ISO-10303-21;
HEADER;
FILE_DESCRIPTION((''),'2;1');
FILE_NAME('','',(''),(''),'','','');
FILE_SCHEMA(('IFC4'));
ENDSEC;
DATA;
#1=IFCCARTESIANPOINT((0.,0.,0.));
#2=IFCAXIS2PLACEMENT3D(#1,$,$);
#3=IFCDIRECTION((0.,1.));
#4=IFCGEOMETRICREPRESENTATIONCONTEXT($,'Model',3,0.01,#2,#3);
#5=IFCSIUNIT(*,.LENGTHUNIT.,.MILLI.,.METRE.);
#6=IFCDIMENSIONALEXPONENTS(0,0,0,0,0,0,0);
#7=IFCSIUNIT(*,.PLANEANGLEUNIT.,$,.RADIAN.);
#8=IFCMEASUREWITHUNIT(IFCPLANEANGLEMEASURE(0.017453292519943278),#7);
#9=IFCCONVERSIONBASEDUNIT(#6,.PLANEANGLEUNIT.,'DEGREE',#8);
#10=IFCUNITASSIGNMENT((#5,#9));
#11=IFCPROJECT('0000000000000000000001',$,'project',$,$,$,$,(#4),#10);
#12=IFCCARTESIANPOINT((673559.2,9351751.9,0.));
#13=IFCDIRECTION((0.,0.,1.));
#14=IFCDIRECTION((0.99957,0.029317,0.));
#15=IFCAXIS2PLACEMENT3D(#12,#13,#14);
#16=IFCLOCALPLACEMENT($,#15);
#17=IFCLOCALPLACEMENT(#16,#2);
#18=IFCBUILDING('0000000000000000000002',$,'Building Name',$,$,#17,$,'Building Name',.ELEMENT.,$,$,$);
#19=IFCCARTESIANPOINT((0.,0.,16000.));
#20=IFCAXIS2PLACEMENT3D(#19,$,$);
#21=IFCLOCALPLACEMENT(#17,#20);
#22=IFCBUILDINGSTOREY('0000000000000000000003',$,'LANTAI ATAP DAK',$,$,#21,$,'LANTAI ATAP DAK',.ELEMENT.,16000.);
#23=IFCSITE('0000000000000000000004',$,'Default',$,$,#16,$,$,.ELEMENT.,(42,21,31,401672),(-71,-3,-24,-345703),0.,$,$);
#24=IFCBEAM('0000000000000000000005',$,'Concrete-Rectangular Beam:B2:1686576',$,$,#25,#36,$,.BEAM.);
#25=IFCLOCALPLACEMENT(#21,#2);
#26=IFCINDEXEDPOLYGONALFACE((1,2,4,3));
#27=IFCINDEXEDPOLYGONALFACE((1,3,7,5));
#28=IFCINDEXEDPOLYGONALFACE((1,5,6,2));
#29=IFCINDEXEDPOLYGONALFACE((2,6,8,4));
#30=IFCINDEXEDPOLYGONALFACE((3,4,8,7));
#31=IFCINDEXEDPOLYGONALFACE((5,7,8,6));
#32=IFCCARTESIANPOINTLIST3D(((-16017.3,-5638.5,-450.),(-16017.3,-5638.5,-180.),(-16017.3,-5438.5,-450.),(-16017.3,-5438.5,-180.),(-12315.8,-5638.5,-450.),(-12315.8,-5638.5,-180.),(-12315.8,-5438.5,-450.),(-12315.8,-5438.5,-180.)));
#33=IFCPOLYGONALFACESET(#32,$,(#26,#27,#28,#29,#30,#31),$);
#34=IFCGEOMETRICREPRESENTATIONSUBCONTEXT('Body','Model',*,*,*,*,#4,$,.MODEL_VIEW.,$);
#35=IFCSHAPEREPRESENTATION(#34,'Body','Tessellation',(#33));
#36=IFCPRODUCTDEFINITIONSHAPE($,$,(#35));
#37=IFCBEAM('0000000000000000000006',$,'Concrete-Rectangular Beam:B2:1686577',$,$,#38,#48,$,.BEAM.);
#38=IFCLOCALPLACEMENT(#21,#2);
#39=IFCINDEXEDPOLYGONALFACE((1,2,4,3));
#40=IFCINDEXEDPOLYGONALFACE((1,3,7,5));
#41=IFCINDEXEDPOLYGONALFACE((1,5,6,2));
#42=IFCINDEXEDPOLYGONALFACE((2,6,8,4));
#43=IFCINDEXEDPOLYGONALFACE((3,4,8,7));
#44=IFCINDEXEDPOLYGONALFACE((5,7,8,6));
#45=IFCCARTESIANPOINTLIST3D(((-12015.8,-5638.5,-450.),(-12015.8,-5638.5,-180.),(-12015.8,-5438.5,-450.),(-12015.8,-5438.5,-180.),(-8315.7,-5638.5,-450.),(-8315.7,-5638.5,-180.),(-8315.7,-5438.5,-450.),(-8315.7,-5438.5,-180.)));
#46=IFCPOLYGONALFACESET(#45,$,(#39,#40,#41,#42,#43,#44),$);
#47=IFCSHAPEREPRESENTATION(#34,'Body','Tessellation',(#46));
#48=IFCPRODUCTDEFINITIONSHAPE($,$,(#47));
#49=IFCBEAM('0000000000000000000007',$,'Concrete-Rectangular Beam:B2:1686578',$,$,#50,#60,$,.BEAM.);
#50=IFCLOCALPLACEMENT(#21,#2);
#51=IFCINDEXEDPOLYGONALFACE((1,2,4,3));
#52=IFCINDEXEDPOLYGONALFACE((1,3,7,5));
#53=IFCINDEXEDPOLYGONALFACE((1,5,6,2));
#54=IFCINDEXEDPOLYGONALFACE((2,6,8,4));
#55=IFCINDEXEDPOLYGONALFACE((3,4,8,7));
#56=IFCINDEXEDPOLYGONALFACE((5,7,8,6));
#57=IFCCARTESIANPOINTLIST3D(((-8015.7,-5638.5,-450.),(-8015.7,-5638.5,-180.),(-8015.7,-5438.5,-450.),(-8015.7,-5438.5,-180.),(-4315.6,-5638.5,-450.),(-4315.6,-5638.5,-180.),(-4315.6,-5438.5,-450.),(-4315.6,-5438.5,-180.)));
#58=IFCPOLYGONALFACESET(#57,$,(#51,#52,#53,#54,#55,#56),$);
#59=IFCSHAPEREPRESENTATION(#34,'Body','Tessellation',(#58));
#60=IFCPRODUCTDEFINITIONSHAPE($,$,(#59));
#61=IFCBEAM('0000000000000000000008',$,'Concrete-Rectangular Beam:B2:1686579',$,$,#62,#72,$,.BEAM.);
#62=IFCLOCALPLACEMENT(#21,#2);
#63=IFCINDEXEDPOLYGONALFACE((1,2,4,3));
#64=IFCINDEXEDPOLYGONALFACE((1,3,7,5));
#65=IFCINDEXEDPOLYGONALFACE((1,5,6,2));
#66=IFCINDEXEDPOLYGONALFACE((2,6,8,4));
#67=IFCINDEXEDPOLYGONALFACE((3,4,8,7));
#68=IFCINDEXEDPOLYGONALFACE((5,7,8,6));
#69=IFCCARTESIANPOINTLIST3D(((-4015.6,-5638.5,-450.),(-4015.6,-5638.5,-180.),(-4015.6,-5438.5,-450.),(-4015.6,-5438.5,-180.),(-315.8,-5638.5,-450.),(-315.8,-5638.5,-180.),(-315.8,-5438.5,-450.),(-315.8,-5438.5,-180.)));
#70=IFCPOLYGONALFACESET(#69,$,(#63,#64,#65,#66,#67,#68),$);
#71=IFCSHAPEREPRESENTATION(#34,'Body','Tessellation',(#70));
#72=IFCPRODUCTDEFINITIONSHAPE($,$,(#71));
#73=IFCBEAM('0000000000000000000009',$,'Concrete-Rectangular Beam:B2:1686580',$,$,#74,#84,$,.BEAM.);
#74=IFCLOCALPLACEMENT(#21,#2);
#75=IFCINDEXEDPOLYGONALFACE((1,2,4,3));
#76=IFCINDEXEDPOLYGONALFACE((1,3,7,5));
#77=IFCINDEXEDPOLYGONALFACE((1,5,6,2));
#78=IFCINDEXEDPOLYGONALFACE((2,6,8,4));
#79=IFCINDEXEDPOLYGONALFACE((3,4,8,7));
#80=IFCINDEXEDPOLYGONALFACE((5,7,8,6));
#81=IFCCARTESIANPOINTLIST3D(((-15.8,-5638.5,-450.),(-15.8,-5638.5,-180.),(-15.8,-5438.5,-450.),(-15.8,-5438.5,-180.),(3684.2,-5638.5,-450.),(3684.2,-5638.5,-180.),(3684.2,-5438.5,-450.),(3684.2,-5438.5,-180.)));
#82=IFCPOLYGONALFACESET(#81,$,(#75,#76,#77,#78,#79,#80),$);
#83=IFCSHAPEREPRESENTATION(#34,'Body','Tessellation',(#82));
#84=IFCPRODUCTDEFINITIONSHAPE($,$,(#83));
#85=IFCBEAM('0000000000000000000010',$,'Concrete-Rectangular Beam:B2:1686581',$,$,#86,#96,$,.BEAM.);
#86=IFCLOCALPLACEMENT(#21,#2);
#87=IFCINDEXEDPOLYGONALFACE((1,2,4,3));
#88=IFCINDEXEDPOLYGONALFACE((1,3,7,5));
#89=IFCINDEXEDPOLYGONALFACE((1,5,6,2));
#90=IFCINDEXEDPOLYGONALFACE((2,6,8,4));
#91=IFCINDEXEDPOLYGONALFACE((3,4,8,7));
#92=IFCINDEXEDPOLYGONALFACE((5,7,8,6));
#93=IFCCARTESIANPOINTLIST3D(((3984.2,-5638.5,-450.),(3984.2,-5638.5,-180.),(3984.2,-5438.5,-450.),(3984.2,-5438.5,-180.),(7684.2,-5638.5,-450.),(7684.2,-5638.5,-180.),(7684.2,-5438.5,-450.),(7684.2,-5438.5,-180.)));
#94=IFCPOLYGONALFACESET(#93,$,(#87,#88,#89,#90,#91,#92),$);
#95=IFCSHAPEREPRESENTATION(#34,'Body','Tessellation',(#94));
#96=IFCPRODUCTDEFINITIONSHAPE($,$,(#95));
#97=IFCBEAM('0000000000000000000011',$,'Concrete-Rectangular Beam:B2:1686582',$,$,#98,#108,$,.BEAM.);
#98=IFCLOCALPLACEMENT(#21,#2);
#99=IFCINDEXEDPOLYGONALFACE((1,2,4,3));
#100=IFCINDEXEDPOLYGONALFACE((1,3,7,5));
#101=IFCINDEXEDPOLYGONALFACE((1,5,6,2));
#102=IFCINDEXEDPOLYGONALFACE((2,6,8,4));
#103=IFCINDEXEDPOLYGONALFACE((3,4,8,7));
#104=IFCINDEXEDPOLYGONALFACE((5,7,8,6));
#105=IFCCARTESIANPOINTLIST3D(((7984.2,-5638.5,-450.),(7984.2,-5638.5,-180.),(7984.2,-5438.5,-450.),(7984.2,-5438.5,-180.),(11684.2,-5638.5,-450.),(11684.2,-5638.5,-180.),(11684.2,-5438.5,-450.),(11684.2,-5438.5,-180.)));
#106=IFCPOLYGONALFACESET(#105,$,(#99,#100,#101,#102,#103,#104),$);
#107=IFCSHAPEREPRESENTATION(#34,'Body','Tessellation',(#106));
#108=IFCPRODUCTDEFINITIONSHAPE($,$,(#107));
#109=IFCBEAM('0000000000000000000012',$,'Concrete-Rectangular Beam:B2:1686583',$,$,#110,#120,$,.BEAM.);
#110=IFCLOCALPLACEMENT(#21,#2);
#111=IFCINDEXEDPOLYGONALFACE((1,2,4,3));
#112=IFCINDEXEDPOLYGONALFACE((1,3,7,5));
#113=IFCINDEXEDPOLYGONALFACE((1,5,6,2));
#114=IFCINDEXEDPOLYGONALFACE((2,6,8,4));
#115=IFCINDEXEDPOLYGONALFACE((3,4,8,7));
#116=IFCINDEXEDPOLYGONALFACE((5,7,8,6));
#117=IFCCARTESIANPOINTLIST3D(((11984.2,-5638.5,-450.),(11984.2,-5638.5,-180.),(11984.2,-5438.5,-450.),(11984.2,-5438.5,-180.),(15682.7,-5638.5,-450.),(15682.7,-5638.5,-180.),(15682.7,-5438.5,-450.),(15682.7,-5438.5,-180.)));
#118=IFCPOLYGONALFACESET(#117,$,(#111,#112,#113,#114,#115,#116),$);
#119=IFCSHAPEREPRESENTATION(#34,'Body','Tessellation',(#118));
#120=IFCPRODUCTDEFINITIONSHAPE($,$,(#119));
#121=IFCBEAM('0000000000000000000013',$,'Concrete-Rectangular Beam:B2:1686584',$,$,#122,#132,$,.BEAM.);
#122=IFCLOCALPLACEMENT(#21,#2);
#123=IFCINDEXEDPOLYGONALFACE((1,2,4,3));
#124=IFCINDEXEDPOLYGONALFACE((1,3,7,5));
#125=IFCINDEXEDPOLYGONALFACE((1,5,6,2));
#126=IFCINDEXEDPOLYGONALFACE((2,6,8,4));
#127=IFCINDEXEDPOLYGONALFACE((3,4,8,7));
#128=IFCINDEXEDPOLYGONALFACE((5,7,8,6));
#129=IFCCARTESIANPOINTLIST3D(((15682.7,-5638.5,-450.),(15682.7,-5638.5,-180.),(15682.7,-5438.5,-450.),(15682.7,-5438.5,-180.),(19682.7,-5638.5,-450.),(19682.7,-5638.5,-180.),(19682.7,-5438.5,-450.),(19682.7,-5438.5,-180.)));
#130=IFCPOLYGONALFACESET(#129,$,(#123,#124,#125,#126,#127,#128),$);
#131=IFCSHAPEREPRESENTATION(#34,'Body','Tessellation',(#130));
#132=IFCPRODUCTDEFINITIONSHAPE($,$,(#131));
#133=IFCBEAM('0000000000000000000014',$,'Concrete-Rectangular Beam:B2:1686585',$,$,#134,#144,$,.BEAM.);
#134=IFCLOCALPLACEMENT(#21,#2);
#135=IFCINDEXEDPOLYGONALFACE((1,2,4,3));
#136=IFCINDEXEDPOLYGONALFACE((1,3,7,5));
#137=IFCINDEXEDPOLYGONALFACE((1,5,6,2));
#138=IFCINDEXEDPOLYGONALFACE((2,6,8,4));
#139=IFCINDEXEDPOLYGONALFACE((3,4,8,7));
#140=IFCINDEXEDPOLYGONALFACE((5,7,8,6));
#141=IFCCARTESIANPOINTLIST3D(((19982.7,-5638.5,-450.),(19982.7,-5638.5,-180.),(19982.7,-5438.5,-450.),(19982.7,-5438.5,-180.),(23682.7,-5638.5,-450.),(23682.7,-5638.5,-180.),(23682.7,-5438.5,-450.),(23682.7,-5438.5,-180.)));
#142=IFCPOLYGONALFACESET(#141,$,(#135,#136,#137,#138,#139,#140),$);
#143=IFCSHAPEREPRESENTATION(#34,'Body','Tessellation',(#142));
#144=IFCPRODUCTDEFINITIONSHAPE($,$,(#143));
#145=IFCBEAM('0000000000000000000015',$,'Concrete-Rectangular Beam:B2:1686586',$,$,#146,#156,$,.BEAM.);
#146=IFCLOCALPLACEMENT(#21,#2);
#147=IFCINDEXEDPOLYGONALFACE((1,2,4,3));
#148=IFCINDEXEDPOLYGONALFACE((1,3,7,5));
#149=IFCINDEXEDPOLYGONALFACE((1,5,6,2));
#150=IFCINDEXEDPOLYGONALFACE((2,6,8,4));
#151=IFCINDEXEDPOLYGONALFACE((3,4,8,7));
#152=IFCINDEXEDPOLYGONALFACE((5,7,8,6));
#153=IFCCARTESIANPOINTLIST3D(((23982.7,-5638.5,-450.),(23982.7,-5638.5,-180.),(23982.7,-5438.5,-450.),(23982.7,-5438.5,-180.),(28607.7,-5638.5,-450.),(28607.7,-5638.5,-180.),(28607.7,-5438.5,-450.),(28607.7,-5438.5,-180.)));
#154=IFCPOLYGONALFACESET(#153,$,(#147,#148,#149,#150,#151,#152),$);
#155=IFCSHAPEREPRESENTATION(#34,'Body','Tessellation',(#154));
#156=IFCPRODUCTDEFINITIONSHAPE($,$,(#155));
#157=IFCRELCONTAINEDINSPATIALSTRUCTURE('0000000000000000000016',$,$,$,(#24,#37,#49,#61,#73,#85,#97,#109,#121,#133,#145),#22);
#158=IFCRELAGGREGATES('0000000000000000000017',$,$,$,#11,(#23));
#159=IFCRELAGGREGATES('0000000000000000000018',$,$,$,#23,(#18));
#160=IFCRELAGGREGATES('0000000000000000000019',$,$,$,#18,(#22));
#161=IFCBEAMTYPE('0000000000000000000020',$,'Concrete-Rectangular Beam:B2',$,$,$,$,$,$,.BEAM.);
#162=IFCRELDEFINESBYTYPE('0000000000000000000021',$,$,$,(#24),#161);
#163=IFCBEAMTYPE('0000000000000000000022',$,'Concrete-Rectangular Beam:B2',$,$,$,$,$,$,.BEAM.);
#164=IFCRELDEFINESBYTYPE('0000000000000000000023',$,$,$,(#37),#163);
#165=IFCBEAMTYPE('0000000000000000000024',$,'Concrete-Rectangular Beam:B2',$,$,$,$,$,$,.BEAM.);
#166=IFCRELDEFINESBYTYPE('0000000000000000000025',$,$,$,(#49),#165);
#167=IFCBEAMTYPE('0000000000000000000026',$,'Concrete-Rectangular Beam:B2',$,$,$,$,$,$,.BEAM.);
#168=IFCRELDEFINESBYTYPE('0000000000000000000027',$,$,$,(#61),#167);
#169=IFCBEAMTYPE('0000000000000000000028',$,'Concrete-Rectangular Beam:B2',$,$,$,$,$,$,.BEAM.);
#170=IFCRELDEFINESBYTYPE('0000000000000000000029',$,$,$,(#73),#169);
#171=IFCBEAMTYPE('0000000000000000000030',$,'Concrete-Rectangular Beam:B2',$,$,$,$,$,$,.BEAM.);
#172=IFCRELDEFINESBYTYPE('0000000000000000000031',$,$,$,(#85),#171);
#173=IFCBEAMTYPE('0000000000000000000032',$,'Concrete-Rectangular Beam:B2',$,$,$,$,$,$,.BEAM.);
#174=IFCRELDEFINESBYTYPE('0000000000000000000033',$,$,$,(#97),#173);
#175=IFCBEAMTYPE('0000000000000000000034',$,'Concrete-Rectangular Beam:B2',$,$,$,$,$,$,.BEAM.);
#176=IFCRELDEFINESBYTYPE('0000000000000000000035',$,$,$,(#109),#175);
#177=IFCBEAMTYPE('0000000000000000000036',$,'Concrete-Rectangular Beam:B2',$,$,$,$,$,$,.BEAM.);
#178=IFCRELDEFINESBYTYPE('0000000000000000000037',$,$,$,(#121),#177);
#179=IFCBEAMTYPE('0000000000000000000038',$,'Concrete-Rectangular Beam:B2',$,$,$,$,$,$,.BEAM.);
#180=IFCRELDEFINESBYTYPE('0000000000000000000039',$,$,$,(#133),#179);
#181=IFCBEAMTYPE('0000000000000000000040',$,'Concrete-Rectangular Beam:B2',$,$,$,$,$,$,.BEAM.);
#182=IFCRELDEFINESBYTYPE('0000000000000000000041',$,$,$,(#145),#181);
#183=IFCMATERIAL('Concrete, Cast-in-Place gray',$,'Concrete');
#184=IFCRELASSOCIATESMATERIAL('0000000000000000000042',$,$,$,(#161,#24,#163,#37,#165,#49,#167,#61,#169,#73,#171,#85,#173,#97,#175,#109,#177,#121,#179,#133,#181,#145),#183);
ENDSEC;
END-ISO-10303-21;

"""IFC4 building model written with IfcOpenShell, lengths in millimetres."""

from ifc_helpers import new_model, entity, si_unit, converted_unit, direction, frame, origin, place, context, subcontext, project, spatial, indexed_curve, outline, extrude, source, transform, mapped, material, type_object, type_shapes, element, save


model = new_model("IFC4")

# Units and contexts
model_context = context("Model", 3, precision=0.01, world=origin(), true_north=direction((0.0, 1.0)))
body_context = subcontext(model_context, "Body", "Model", "MODEL_VIEW")
ifc_project = project(units=[si_unit("LENGTHUNIT", "METRE", prefix="MILLI"), converted_unit("PLANEANGLEUNIT", "DEGREE", entity("IfcPlaneAngleMeasure", 0.017453292519943278), si_unit("PLANEANGLEUNIT", "RADIAN"), dimensions=[0, 0, 0, 0, 0, 0, 0])], contexts=[model_context])

# Site, building, storey
site_placement = place(None, frame((673559.2, 9351751.9, 0.0), z_axis=(0.0, 0.0, 1.0), x_axis=(0.99957, 0.029317, 0.0)))
site = spatial("IfcSite", under=ifc_project, at=site_placement, Name="Default", CompositionType="ELEMENT", RefLatitude=(42, 21, 31, 401672), RefLongitude=(-71, -3, -24, -345703), RefElevation=0.0)
building_placement = place(site_placement, origin())
building = spatial("IfcBuilding", under=site, at=building_placement, Name="Building Name", LongName="Building Name", CompositionType="ELEMENT")
storey_placement = place(building_placement, frame((0.0, 0.0, 16000.0)))
storey = spatial("IfcBuildingStorey", under=building, at=storey_placement, Name="LANTAI ATAP DAK", LongName="LANTAI ATAP DAK", CompositionType="ELEMENT", Elevation=16000.0)

# Beams
ifc_material = material(Name="Concrete, Cast-in-Place gray", Category="Concrete")
beam_type_1 = type_object("IfcBeamType", Name="Concrete-Rectangular Beam:B2", PredefinedType="BEAM", material=ifc_material)
shared_shape_1 = source(origin(), body_context, "Body", "SweptSolid", [
    extrude(outline(indexed_curve([(-135.0, -100.0), (135.0, -100.0), (135.0, 100.0), (-135.0, 100.0), (-135.0, -100.0)], self_intersect=False)), frame((-16017.3, -5538.5, 15685.0), z_axis=(1.0, 0.0, 0.0), x_axis=(0.0, 0.0, -1.0)), (0.0, 0.0, 1.0), 3701.5),
])
type_shapes(beam_type_1, [shared_shape_1])
beam_1_placement = place(storey_placement, frame((0.0, 0.0, -16000.0)))
element("IfcBeam", 1, at=beam_1_placement, inside=storey, type_object=beam_type_1, material=ifc_material, Name="Concrete-Rectangular Beam:B2:1686576", PredefinedType="BEAM", context=body_context, shape_type="MappedRepresentation", body=[
    mapped(shared_shape_1, transform((0.0, 0.0, 0.0), scale=1.0)),
])
beam_type_2 = type_object("IfcBeamType", Name="Concrete-Rectangular Beam:B2", PredefinedType="BEAM", material=ifc_material)
shared_shape_2 = source(origin(), body_context, "Body", "SweptSolid", [
    extrude(outline(indexed_curve([(-135.0, -100.0), (135.0, -100.0), (135.0, 100.0), (-135.0, 100.0), (-135.0, -100.0)], self_intersect=False)), frame((-8315.7, -5538.5, 15685.0), z_axis=(-1.0, 0.0, 0.0), x_axis=(0.0, 0.0, -1.0)), (0.0, 0.0, 1.0), 3700.1),
])
type_shapes(beam_type_2, [shared_shape_2])
beam_2_placement = place(storey_placement, frame((0.0, 0.0, -16000.0)))
element("IfcBeam", 2, at=beam_2_placement, inside=storey, type_object=beam_type_2, material=ifc_material, Name="Concrete-Rectangular Beam:B2:1686577", PredefinedType="BEAM", context=body_context, shape_type="MappedRepresentation", body=[
    mapped(shared_shape_2, transform((0.0, 0.0, 0.0), scale=1.0)),
])
beam_type_3 = type_object("IfcBeamType", Name="Concrete-Rectangular Beam:B2", PredefinedType="BEAM", material=ifc_material)
shared_shape_3 = source(origin(), body_context, "Body", "SweptSolid", [
    extrude(outline(indexed_curve([(-135.0, -100.0), (135.0, -100.0), (135.0, 100.0), (-135.0, 100.0), (-135.0, -100.0)], self_intersect=False)), frame((-8015.7, -5538.5, 15685.0), z_axis=(1.0, 0.0, 0.0), x_axis=(0.0, 0.0, -1.0)), (0.0, 0.0, 1.0), 3700.1),
])
type_shapes(beam_type_3, [shared_shape_3])
beam_3_placement = place(storey_placement, frame((0.0, 0.0, -16000.0)))
element("IfcBeam", 3, at=beam_3_placement, inside=storey, type_object=beam_type_3, material=ifc_material, Name="Concrete-Rectangular Beam:B2:1686578", PredefinedType="BEAM", context=body_context, shape_type="MappedRepresentation", body=[
    mapped(shared_shape_3, transform((0.0, 0.0, 0.0), scale=1.0)),
])
beam_type_4 = type_object("IfcBeamType", Name="Concrete-Rectangular Beam:B2", PredefinedType="BEAM", material=ifc_material)
shared_shape_4 = source(origin(), body_context, "Body", "SweptSolid", [
    extrude(outline(indexed_curve([(-135.0, -100.0), (135.0, -100.0), (135.0, 100.0), (-135.0, 100.0), (-135.0, -100.0)], self_intersect=False)), frame((-4015.6, -5538.5, 15685.0), z_axis=(1.0, 0.0, 0.0), x_axis=(0.0, 0.0, -1.0)), (0.0, 0.0, 1.0), 3699.7),
])
type_shapes(beam_type_4, [shared_shape_4])
beam_4_placement = place(storey_placement, frame((0.0, 0.0, -16000.0)))
element("IfcBeam", 4, at=beam_4_placement, inside=storey, type_object=beam_type_4, material=ifc_material, Name="Concrete-Rectangular Beam:B2:1686579", PredefinedType="BEAM", context=body_context, shape_type="MappedRepresentation", body=[
    mapped(shared_shape_4, transform((0.0, 0.0, 0.0), scale=1.0)),
])
beam_type_5 = type_object("IfcBeamType", Name="Concrete-Rectangular Beam:B2", PredefinedType="BEAM", material=ifc_material)
shared_shape_5 = source(origin(), body_context, "Body", "SweptSolid", [
    extrude(outline(indexed_curve([(-135.0, -100.0), (135.0, -100.0), (135.0, 100.0), (-135.0, 100.0), (-135.0, -100.0)], self_intersect=False)), frame((-15.8, -5538.5, 15685.0), z_axis=(1.0, 0.0, 0.0), x_axis=(0.0, 0.0, -1.0)), (0.0, 0.0, 1.0), 3700.0),
])
type_shapes(beam_type_5, [shared_shape_5])
beam_5_placement = place(storey_placement, frame((0.0, 0.0, -16000.0)))
element("IfcBeam", 5, at=beam_5_placement, inside=storey, type_object=beam_type_5, material=ifc_material, Name="Concrete-Rectangular Beam:B2:1686580", PredefinedType="BEAM", context=body_context, shape_type="MappedRepresentation", body=[
    mapped(shared_shape_5, transform((0.0, 0.0, 0.0), scale=1.0)),
])
beam_type_6 = type_object("IfcBeamType", Name="Concrete-Rectangular Beam:B2", PredefinedType="BEAM", material=ifc_material)
shared_shape_6 = source(origin(), body_context, "Body", "SweptSolid", [
    extrude(outline(indexed_curve([(-135.0, -100.0), (135.0, -100.0), (135.0, 100.0), (-135.0, 100.0), (-135.0, -100.0)], self_intersect=False)), frame((3984.2, -5538.5, 15685.0), z_axis=(1.0, 0.0, 0.0), x_axis=(0.0, 0.0, -1.0)), (0.0, 0.0, 1.0), 3700.0),
])
type_shapes(beam_type_6, [shared_shape_6])
beam_6_placement = place(storey_placement, frame((0.0, 0.0, -16000.0)))
element("IfcBeam", 6, at=beam_6_placement, inside=storey, type_object=beam_type_6, material=ifc_material, Name="Concrete-Rectangular Beam:B2:1686581", PredefinedType="BEAM", context=body_context, shape_type="MappedRepresentation", body=[
    mapped(shared_shape_6, transform((0.0, 0.0, 0.0), scale=1.0)),
])
beam_type_7 = type_object("IfcBeamType", Name="Concrete-Rectangular Beam:B2", PredefinedType="BEAM", material=ifc_material)
shared_shape_7 = source(origin(), body_context, "Body", "SweptSolid", [
    extrude(outline(indexed_curve([(-135.0, -100.0), (135.0, -100.0), (135.0, 100.0), (-135.0, 100.0), (-135.0, -100.0)], self_intersect=False)), frame((7984.2, -5538.5, 15685.0), z_axis=(1.0, 0.0, 0.0), x_axis=(0.0, 0.0, -1.0)), (0.0, 0.0, 1.0), 3700.0),
])
type_shapes(beam_type_7, [shared_shape_7])
beam_7_placement = place(storey_placement, frame((0.0, 0.0, -16000.0)))
element("IfcBeam", 7, at=beam_7_placement, inside=storey, type_object=beam_type_7, material=ifc_material, Name="Concrete-Rectangular Beam:B2:1686582", PredefinedType="BEAM", context=body_context, shape_type="MappedRepresentation", body=[
    mapped(shared_shape_7, transform((0.0, 0.0, 0.0), scale=1.0)),
])
beam_type_8 = type_object("IfcBeamType", Name="Concrete-Rectangular Beam:B2", PredefinedType="BEAM", material=ifc_material)
shared_shape_8 = source(origin(), body_context, "Body", "SweptSolid", [
    extrude(outline(indexed_curve([(-135.0, -100.0), (135.0, -100.0), (135.0, 100.0), (-135.0, 100.0), (-135.0, -100.0)], self_intersect=False)), frame((11984.2, -5538.5, 15685.0), z_axis=(1.0, 0.0, 0.0), x_axis=(0.0, 0.0, -1.0)), (0.0, 0.0, 1.0), 3698.5),
])
type_shapes(beam_type_8, [shared_shape_8])
beam_8_placement = place(storey_placement, frame((0.0, 0.0, -16000.0)))
element("IfcBeam", 8, at=beam_8_placement, inside=storey, type_object=beam_type_8, material=ifc_material, Name="Concrete-Rectangular Beam:B2:1686583", PredefinedType="BEAM", context=body_context, shape_type="MappedRepresentation", body=[
    mapped(shared_shape_8, transform((0.0, 0.0, 0.0), scale=1.0)),
])
beam_type_9 = type_object("IfcBeamType", Name="Concrete-Rectangular Beam:B2", PredefinedType="BEAM", material=ifc_material)
shared_shape_9 = source(origin(), body_context, "Body", "SweptSolid", [
    extrude(outline(indexed_curve([(-135.0, -100.0), (135.0, -100.0), (135.0, 100.0), (-135.0, 100.0), (-135.0, -100.0)], self_intersect=False)), frame((15682.7, -5538.5, 15685.0), z_axis=(1.0, 0.0, 0.0), x_axis=(0.0, 0.0, -1.0)), (0.0, 0.0, 1.0), 4000.0),
])
type_shapes(beam_type_9, [shared_shape_9])
beam_9_placement = place(storey_placement, frame((0.0, 0.0, -16000.0)))
element("IfcBeam", 9, at=beam_9_placement, inside=storey, type_object=beam_type_9, material=ifc_material, Name="Concrete-Rectangular Beam:B2:1686584", PredefinedType="BEAM", context=body_context, shape_type="MappedRepresentation", body=[
    mapped(shared_shape_9, transform((0.0, 0.0, 0.0), scale=1.0)),
])
beam_type_10 = type_object("IfcBeamType", Name="Concrete-Rectangular Beam:B2", PredefinedType="BEAM", material=ifc_material)
shared_shape_10 = source(origin(), body_context, "Body", "SweptSolid", [
    extrude(outline(indexed_curve([(-135.0, -100.0), (135.0, -100.0), (135.0, 100.0), (-135.0, 100.0), (-135.0, -100.0)], self_intersect=False)), frame((19982.7, -5538.5, 15685.0), z_axis=(1.0, 0.0, 0.0), x_axis=(0.0, 0.0, -1.0)), (0.0, 0.0, 1.0), 3700.0),
])
type_shapes(beam_type_10, [shared_shape_10])
beam_10_placement = place(storey_placement, frame((0.0, 0.0, -16000.0)))
element("IfcBeam", 10, at=beam_10_placement, inside=storey, type_object=beam_type_10, material=ifc_material, Name="Concrete-Rectangular Beam:B2:1686585", PredefinedType="BEAM", context=body_context, shape_type="MappedRepresentation", body=[
    mapped(shared_shape_10, transform((0.0, 0.0, 0.0), scale=1.0)),
])
beam_type_11 = type_object("IfcBeamType", Name="Concrete-Rectangular Beam:B2", PredefinedType="BEAM", material=ifc_material)
shared_shape_11 = source(origin(), body_context, "Body", "SweptSolid", [
    extrude(outline(indexed_curve([(-135.0, -100.0), (135.0, -100.0), (135.0, 100.0), (-135.0, 100.0), (-135.0, -100.0)], self_intersect=False)), frame((23982.7, -5538.5, 15685.0), z_axis=(1.0, 0.0, 0.0), x_axis=(0.0, 0.0, -1.0)), (0.0, 0.0, 1.0), 4625.0),
])
type_shapes(beam_type_11, [shared_shape_11])
beam_11_placement = place(storey_placement, frame((0.0, 0.0, -16000.0)))
element("IfcBeam", 11, at=beam_11_placement, inside=storey, type_object=beam_type_11, material=ifc_material, Name="Concrete-Rectangular Beam:B2:1686586", PredefinedType="BEAM", context=body_context, shape_type="MappedRepresentation", body=[
    mapped(shared_shape_11, transform((0.0, 0.0, 0.0), scale=1.0)),
])

save(model, "model.ifc")
